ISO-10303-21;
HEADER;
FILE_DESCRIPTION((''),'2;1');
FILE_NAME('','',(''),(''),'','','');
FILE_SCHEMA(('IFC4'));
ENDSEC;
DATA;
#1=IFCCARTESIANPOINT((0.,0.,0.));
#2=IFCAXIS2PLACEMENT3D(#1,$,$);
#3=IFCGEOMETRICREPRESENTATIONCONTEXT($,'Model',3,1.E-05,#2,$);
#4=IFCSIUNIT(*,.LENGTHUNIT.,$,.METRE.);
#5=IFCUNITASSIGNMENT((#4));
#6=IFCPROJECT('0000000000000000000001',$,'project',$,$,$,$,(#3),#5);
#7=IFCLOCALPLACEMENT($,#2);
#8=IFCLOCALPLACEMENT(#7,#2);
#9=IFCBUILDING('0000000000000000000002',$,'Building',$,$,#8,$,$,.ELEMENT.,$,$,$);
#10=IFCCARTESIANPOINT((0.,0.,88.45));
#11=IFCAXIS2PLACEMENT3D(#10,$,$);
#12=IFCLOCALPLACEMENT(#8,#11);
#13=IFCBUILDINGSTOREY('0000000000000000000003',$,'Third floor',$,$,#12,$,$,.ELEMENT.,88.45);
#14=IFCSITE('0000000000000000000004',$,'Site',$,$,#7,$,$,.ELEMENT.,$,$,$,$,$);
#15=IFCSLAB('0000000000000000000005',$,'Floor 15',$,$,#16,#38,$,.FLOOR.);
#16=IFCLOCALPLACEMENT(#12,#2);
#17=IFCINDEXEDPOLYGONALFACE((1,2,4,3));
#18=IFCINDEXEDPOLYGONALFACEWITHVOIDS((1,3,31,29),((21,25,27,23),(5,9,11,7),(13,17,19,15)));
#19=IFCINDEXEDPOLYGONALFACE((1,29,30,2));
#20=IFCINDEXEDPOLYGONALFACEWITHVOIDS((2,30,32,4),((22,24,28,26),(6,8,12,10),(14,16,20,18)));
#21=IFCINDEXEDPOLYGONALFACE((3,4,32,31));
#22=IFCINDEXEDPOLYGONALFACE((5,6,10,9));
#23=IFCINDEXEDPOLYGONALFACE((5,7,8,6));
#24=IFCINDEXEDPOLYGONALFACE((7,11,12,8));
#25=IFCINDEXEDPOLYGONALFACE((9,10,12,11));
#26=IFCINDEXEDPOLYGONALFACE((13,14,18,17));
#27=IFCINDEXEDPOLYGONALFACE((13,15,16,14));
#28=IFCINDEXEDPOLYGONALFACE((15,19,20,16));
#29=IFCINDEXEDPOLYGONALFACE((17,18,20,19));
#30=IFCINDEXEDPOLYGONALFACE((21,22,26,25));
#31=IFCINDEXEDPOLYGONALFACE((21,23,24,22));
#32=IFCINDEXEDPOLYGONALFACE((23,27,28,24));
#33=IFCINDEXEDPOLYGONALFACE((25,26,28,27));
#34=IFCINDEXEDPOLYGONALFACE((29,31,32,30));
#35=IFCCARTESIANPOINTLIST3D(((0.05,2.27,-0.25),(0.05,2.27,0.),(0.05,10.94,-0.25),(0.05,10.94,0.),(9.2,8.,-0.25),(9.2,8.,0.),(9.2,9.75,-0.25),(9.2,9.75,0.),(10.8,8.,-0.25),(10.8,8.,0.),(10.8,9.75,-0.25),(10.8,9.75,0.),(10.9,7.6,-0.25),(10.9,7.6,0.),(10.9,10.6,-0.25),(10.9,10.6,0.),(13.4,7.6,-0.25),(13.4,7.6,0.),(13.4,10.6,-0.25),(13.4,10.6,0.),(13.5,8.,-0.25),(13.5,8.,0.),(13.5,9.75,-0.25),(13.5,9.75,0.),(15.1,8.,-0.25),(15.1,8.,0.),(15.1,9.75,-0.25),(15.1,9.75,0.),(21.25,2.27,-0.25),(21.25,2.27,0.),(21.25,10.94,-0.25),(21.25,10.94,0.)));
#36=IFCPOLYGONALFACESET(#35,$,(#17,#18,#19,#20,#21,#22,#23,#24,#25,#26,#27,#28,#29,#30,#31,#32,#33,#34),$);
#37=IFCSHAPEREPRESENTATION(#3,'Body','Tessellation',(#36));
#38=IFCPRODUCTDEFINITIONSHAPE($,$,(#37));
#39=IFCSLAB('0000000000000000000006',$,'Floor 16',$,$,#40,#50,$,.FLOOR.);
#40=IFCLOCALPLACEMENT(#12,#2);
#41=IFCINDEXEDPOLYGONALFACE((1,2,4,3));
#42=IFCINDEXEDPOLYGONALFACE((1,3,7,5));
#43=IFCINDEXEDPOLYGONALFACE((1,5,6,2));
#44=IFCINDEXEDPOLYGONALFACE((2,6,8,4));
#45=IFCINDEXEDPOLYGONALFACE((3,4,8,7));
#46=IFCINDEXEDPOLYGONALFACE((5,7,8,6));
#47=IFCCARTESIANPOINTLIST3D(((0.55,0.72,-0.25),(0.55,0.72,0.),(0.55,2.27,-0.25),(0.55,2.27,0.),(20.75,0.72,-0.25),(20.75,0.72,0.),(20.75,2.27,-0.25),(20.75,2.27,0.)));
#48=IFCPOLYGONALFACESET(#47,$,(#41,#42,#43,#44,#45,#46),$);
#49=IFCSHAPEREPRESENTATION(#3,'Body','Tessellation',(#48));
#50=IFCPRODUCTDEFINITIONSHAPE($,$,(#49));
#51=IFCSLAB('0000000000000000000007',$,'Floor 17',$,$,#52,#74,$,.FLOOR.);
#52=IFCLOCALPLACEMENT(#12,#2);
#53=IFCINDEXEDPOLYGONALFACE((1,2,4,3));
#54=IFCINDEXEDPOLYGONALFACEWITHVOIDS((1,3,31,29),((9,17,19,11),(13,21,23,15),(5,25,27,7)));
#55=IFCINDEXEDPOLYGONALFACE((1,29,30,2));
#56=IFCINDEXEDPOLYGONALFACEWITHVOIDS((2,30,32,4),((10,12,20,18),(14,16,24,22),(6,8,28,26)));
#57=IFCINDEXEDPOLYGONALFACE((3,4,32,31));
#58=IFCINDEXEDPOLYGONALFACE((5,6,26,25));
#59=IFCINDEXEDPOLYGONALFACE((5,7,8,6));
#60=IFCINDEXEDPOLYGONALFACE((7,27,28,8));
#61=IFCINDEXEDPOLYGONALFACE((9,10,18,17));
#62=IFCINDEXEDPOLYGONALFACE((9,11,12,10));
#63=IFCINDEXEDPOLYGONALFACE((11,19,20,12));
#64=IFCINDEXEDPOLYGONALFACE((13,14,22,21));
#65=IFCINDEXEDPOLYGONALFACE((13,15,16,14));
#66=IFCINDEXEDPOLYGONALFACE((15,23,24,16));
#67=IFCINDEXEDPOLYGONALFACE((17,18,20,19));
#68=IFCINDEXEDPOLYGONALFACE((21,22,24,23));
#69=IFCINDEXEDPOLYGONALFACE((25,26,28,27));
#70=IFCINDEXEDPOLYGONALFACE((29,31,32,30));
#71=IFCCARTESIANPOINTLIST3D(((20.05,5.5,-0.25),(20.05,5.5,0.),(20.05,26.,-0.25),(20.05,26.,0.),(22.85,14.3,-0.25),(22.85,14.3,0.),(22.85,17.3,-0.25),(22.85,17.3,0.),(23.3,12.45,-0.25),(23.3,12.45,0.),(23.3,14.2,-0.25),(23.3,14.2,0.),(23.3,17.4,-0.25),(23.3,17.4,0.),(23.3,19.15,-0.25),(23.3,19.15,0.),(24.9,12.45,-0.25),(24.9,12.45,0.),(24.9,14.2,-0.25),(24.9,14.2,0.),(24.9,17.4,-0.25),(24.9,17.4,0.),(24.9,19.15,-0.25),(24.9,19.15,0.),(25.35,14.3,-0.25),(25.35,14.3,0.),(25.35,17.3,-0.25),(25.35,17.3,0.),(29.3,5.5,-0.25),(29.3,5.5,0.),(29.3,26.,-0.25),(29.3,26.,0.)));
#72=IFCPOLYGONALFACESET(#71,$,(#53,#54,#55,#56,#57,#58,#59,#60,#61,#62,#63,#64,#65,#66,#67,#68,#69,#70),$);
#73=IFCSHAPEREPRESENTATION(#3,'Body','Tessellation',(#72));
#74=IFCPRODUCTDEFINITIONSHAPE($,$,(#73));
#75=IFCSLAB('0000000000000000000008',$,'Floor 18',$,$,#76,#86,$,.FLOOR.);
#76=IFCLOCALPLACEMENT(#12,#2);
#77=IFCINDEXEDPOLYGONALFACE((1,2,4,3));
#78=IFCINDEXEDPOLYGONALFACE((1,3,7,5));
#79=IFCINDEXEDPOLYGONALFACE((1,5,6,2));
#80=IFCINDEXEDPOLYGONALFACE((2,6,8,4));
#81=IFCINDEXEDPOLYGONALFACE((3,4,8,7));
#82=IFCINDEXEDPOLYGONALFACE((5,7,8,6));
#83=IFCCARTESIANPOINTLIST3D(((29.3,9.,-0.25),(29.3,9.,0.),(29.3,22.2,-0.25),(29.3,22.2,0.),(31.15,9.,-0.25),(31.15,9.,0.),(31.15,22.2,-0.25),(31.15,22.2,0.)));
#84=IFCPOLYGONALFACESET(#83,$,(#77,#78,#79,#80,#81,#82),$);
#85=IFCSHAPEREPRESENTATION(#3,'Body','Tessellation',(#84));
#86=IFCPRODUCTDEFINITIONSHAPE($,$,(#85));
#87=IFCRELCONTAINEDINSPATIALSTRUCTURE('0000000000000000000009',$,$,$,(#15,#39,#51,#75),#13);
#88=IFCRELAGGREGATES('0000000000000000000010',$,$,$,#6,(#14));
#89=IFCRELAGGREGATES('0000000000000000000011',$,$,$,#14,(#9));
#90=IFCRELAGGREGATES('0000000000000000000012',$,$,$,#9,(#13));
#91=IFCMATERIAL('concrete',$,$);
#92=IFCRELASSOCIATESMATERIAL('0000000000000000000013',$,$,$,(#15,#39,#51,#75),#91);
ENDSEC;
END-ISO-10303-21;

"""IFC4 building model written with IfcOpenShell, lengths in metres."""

from ifc_helpers import new_model, si_unit, frame, origin, place, context, project, spatial, polyline, outline, extrude, material, element, save


model = new_model("IFC4")

# Units and contexts
model_context = context("Model", 3, precision=1e-05, world=origin())
ifc_project = project(units=[si_unit("LENGTHUNIT", "METRE")], contexts=[model_context])

# Site, building, storey
site_placement = place(None, origin())
site = spatial("IfcSite", under=ifc_project, at=site_placement, Name="Site", CompositionType="ELEMENT")
building_placement = place(site_placement, origin())
building = spatial("IfcBuilding", under=site, at=building_placement, Name="Building", CompositionType="ELEMENT")
storey_placement = place(building_placement, frame((0.0, 0.0, 88.45)))
storey = spatial("IfcBuildingStorey", under=building, at=storey_placement, Name="Third floor", CompositionType="ELEMENT", Elevation=88.45)

# Slabs
ifc_material = material(Name="concrete")
slab_1_placement = place(storey_placement, frame((0.0, 0.0, -0.25), z_axis=(0.0, 0.0, 1.0), x_axis=(1.0, 0.0, 0.0)))
element("IfcSlab", 1, at=slab_1_placement, inside=storey, material=ifc_material, Name="Floor 15", PredefinedType="FLOOR", context=model_context, shape_type="SweptSolid", body=[
    extrude(outline(polyline([(0.05, 2.27), (21.25, 2.27), (21.25, 10.94), (0.05, 10.94), (0.05, 2.27)]), holes=[polyline([(10.9, 7.6), (13.4, 7.6), (13.4, 10.6), (10.9, 10.6), (10.9, 7.6)]), polyline([(9.2, 8.0), (10.8, 8.0), (10.8, 9.75), (9.2, 9.75), (9.2, 8.0)]), polyline([(13.5, 8.0), (15.1, 8.0), (15.1, 9.75), (13.5, 9.75), (13.5, 8.0)])]), origin(), (0.0, 0.0, 1.0), 0.25),
])
slab_2_placement = place(storey_placement, frame((0.0, 0.0, -0.25), z_axis=(0.0, 0.0, 1.0), x_axis=(1.0, 0.0, 0.0)))
element("IfcSlab", 2, at=slab_2_placement, inside=storey, material=ifc_material, Name="Floor 16", PredefinedType="FLOOR", context=model_context, shape_type="SweptSolid", body=[
    extrude(outline(polyline([(0.55, 0.72), (20.75, 0.72), (20.75, 2.27), (0.55, 2.27), (0.55, 0.72)])), origin(), (0.0, 0.0, 1.0), 0.25),
])
slab_3_placement = place(storey_placement, frame((0.0, 0.0, -0.25), z_axis=(0.0, 0.0, 1.0), x_axis=(1.0, 0.0, 0.0)))
element("IfcSlab", 3, at=slab_3_placement, inside=storey, material=ifc_material, Name="Floor 17", PredefinedType="FLOOR", context=model_context, shape_type="SweptSolid", body=[
    extrude(outline(polyline([(20.05, 5.5), (29.3, 5.5), (29.3, 26.0), (20.05, 26.0), (20.05, 5.5)]), holes=[polyline([(22.85, 14.3), (25.35, 14.3), (25.35, 17.3), (22.85, 17.3), (22.85, 14.3)]), polyline([(23.3, 17.4), (24.9, 17.4), (24.9, 19.15), (23.3, 19.15), (23.3, 17.4)]), polyline([(23.3, 12.45), (24.9, 12.45), (24.9, 14.2), (23.3, 14.2), (23.3, 12.45)])]), origin(), (0.0, 0.0, 1.0), 0.25),
])
slab_4_placement = place(storey_placement, frame((0.0, 0.0, -0.25), z_axis=(0.0, 0.0, 1.0), x_axis=(1.0, 0.0, 0.0)))
element("IfcSlab", 4, at=slab_4_placement, inside=storey, material=ifc_material, Name="Floor 18", PredefinedType="FLOOR", context=model_context, shape_type="SweptSolid", body=[
    extrude(outline(polyline([(29.3, 9.0), (31.15, 9.0), (31.15, 22.2), (29.3, 22.2), (29.3, 9.0)])), origin(), (0.0, 0.0, 1.0), 0.25),
])

save(model, "model.ifc")
